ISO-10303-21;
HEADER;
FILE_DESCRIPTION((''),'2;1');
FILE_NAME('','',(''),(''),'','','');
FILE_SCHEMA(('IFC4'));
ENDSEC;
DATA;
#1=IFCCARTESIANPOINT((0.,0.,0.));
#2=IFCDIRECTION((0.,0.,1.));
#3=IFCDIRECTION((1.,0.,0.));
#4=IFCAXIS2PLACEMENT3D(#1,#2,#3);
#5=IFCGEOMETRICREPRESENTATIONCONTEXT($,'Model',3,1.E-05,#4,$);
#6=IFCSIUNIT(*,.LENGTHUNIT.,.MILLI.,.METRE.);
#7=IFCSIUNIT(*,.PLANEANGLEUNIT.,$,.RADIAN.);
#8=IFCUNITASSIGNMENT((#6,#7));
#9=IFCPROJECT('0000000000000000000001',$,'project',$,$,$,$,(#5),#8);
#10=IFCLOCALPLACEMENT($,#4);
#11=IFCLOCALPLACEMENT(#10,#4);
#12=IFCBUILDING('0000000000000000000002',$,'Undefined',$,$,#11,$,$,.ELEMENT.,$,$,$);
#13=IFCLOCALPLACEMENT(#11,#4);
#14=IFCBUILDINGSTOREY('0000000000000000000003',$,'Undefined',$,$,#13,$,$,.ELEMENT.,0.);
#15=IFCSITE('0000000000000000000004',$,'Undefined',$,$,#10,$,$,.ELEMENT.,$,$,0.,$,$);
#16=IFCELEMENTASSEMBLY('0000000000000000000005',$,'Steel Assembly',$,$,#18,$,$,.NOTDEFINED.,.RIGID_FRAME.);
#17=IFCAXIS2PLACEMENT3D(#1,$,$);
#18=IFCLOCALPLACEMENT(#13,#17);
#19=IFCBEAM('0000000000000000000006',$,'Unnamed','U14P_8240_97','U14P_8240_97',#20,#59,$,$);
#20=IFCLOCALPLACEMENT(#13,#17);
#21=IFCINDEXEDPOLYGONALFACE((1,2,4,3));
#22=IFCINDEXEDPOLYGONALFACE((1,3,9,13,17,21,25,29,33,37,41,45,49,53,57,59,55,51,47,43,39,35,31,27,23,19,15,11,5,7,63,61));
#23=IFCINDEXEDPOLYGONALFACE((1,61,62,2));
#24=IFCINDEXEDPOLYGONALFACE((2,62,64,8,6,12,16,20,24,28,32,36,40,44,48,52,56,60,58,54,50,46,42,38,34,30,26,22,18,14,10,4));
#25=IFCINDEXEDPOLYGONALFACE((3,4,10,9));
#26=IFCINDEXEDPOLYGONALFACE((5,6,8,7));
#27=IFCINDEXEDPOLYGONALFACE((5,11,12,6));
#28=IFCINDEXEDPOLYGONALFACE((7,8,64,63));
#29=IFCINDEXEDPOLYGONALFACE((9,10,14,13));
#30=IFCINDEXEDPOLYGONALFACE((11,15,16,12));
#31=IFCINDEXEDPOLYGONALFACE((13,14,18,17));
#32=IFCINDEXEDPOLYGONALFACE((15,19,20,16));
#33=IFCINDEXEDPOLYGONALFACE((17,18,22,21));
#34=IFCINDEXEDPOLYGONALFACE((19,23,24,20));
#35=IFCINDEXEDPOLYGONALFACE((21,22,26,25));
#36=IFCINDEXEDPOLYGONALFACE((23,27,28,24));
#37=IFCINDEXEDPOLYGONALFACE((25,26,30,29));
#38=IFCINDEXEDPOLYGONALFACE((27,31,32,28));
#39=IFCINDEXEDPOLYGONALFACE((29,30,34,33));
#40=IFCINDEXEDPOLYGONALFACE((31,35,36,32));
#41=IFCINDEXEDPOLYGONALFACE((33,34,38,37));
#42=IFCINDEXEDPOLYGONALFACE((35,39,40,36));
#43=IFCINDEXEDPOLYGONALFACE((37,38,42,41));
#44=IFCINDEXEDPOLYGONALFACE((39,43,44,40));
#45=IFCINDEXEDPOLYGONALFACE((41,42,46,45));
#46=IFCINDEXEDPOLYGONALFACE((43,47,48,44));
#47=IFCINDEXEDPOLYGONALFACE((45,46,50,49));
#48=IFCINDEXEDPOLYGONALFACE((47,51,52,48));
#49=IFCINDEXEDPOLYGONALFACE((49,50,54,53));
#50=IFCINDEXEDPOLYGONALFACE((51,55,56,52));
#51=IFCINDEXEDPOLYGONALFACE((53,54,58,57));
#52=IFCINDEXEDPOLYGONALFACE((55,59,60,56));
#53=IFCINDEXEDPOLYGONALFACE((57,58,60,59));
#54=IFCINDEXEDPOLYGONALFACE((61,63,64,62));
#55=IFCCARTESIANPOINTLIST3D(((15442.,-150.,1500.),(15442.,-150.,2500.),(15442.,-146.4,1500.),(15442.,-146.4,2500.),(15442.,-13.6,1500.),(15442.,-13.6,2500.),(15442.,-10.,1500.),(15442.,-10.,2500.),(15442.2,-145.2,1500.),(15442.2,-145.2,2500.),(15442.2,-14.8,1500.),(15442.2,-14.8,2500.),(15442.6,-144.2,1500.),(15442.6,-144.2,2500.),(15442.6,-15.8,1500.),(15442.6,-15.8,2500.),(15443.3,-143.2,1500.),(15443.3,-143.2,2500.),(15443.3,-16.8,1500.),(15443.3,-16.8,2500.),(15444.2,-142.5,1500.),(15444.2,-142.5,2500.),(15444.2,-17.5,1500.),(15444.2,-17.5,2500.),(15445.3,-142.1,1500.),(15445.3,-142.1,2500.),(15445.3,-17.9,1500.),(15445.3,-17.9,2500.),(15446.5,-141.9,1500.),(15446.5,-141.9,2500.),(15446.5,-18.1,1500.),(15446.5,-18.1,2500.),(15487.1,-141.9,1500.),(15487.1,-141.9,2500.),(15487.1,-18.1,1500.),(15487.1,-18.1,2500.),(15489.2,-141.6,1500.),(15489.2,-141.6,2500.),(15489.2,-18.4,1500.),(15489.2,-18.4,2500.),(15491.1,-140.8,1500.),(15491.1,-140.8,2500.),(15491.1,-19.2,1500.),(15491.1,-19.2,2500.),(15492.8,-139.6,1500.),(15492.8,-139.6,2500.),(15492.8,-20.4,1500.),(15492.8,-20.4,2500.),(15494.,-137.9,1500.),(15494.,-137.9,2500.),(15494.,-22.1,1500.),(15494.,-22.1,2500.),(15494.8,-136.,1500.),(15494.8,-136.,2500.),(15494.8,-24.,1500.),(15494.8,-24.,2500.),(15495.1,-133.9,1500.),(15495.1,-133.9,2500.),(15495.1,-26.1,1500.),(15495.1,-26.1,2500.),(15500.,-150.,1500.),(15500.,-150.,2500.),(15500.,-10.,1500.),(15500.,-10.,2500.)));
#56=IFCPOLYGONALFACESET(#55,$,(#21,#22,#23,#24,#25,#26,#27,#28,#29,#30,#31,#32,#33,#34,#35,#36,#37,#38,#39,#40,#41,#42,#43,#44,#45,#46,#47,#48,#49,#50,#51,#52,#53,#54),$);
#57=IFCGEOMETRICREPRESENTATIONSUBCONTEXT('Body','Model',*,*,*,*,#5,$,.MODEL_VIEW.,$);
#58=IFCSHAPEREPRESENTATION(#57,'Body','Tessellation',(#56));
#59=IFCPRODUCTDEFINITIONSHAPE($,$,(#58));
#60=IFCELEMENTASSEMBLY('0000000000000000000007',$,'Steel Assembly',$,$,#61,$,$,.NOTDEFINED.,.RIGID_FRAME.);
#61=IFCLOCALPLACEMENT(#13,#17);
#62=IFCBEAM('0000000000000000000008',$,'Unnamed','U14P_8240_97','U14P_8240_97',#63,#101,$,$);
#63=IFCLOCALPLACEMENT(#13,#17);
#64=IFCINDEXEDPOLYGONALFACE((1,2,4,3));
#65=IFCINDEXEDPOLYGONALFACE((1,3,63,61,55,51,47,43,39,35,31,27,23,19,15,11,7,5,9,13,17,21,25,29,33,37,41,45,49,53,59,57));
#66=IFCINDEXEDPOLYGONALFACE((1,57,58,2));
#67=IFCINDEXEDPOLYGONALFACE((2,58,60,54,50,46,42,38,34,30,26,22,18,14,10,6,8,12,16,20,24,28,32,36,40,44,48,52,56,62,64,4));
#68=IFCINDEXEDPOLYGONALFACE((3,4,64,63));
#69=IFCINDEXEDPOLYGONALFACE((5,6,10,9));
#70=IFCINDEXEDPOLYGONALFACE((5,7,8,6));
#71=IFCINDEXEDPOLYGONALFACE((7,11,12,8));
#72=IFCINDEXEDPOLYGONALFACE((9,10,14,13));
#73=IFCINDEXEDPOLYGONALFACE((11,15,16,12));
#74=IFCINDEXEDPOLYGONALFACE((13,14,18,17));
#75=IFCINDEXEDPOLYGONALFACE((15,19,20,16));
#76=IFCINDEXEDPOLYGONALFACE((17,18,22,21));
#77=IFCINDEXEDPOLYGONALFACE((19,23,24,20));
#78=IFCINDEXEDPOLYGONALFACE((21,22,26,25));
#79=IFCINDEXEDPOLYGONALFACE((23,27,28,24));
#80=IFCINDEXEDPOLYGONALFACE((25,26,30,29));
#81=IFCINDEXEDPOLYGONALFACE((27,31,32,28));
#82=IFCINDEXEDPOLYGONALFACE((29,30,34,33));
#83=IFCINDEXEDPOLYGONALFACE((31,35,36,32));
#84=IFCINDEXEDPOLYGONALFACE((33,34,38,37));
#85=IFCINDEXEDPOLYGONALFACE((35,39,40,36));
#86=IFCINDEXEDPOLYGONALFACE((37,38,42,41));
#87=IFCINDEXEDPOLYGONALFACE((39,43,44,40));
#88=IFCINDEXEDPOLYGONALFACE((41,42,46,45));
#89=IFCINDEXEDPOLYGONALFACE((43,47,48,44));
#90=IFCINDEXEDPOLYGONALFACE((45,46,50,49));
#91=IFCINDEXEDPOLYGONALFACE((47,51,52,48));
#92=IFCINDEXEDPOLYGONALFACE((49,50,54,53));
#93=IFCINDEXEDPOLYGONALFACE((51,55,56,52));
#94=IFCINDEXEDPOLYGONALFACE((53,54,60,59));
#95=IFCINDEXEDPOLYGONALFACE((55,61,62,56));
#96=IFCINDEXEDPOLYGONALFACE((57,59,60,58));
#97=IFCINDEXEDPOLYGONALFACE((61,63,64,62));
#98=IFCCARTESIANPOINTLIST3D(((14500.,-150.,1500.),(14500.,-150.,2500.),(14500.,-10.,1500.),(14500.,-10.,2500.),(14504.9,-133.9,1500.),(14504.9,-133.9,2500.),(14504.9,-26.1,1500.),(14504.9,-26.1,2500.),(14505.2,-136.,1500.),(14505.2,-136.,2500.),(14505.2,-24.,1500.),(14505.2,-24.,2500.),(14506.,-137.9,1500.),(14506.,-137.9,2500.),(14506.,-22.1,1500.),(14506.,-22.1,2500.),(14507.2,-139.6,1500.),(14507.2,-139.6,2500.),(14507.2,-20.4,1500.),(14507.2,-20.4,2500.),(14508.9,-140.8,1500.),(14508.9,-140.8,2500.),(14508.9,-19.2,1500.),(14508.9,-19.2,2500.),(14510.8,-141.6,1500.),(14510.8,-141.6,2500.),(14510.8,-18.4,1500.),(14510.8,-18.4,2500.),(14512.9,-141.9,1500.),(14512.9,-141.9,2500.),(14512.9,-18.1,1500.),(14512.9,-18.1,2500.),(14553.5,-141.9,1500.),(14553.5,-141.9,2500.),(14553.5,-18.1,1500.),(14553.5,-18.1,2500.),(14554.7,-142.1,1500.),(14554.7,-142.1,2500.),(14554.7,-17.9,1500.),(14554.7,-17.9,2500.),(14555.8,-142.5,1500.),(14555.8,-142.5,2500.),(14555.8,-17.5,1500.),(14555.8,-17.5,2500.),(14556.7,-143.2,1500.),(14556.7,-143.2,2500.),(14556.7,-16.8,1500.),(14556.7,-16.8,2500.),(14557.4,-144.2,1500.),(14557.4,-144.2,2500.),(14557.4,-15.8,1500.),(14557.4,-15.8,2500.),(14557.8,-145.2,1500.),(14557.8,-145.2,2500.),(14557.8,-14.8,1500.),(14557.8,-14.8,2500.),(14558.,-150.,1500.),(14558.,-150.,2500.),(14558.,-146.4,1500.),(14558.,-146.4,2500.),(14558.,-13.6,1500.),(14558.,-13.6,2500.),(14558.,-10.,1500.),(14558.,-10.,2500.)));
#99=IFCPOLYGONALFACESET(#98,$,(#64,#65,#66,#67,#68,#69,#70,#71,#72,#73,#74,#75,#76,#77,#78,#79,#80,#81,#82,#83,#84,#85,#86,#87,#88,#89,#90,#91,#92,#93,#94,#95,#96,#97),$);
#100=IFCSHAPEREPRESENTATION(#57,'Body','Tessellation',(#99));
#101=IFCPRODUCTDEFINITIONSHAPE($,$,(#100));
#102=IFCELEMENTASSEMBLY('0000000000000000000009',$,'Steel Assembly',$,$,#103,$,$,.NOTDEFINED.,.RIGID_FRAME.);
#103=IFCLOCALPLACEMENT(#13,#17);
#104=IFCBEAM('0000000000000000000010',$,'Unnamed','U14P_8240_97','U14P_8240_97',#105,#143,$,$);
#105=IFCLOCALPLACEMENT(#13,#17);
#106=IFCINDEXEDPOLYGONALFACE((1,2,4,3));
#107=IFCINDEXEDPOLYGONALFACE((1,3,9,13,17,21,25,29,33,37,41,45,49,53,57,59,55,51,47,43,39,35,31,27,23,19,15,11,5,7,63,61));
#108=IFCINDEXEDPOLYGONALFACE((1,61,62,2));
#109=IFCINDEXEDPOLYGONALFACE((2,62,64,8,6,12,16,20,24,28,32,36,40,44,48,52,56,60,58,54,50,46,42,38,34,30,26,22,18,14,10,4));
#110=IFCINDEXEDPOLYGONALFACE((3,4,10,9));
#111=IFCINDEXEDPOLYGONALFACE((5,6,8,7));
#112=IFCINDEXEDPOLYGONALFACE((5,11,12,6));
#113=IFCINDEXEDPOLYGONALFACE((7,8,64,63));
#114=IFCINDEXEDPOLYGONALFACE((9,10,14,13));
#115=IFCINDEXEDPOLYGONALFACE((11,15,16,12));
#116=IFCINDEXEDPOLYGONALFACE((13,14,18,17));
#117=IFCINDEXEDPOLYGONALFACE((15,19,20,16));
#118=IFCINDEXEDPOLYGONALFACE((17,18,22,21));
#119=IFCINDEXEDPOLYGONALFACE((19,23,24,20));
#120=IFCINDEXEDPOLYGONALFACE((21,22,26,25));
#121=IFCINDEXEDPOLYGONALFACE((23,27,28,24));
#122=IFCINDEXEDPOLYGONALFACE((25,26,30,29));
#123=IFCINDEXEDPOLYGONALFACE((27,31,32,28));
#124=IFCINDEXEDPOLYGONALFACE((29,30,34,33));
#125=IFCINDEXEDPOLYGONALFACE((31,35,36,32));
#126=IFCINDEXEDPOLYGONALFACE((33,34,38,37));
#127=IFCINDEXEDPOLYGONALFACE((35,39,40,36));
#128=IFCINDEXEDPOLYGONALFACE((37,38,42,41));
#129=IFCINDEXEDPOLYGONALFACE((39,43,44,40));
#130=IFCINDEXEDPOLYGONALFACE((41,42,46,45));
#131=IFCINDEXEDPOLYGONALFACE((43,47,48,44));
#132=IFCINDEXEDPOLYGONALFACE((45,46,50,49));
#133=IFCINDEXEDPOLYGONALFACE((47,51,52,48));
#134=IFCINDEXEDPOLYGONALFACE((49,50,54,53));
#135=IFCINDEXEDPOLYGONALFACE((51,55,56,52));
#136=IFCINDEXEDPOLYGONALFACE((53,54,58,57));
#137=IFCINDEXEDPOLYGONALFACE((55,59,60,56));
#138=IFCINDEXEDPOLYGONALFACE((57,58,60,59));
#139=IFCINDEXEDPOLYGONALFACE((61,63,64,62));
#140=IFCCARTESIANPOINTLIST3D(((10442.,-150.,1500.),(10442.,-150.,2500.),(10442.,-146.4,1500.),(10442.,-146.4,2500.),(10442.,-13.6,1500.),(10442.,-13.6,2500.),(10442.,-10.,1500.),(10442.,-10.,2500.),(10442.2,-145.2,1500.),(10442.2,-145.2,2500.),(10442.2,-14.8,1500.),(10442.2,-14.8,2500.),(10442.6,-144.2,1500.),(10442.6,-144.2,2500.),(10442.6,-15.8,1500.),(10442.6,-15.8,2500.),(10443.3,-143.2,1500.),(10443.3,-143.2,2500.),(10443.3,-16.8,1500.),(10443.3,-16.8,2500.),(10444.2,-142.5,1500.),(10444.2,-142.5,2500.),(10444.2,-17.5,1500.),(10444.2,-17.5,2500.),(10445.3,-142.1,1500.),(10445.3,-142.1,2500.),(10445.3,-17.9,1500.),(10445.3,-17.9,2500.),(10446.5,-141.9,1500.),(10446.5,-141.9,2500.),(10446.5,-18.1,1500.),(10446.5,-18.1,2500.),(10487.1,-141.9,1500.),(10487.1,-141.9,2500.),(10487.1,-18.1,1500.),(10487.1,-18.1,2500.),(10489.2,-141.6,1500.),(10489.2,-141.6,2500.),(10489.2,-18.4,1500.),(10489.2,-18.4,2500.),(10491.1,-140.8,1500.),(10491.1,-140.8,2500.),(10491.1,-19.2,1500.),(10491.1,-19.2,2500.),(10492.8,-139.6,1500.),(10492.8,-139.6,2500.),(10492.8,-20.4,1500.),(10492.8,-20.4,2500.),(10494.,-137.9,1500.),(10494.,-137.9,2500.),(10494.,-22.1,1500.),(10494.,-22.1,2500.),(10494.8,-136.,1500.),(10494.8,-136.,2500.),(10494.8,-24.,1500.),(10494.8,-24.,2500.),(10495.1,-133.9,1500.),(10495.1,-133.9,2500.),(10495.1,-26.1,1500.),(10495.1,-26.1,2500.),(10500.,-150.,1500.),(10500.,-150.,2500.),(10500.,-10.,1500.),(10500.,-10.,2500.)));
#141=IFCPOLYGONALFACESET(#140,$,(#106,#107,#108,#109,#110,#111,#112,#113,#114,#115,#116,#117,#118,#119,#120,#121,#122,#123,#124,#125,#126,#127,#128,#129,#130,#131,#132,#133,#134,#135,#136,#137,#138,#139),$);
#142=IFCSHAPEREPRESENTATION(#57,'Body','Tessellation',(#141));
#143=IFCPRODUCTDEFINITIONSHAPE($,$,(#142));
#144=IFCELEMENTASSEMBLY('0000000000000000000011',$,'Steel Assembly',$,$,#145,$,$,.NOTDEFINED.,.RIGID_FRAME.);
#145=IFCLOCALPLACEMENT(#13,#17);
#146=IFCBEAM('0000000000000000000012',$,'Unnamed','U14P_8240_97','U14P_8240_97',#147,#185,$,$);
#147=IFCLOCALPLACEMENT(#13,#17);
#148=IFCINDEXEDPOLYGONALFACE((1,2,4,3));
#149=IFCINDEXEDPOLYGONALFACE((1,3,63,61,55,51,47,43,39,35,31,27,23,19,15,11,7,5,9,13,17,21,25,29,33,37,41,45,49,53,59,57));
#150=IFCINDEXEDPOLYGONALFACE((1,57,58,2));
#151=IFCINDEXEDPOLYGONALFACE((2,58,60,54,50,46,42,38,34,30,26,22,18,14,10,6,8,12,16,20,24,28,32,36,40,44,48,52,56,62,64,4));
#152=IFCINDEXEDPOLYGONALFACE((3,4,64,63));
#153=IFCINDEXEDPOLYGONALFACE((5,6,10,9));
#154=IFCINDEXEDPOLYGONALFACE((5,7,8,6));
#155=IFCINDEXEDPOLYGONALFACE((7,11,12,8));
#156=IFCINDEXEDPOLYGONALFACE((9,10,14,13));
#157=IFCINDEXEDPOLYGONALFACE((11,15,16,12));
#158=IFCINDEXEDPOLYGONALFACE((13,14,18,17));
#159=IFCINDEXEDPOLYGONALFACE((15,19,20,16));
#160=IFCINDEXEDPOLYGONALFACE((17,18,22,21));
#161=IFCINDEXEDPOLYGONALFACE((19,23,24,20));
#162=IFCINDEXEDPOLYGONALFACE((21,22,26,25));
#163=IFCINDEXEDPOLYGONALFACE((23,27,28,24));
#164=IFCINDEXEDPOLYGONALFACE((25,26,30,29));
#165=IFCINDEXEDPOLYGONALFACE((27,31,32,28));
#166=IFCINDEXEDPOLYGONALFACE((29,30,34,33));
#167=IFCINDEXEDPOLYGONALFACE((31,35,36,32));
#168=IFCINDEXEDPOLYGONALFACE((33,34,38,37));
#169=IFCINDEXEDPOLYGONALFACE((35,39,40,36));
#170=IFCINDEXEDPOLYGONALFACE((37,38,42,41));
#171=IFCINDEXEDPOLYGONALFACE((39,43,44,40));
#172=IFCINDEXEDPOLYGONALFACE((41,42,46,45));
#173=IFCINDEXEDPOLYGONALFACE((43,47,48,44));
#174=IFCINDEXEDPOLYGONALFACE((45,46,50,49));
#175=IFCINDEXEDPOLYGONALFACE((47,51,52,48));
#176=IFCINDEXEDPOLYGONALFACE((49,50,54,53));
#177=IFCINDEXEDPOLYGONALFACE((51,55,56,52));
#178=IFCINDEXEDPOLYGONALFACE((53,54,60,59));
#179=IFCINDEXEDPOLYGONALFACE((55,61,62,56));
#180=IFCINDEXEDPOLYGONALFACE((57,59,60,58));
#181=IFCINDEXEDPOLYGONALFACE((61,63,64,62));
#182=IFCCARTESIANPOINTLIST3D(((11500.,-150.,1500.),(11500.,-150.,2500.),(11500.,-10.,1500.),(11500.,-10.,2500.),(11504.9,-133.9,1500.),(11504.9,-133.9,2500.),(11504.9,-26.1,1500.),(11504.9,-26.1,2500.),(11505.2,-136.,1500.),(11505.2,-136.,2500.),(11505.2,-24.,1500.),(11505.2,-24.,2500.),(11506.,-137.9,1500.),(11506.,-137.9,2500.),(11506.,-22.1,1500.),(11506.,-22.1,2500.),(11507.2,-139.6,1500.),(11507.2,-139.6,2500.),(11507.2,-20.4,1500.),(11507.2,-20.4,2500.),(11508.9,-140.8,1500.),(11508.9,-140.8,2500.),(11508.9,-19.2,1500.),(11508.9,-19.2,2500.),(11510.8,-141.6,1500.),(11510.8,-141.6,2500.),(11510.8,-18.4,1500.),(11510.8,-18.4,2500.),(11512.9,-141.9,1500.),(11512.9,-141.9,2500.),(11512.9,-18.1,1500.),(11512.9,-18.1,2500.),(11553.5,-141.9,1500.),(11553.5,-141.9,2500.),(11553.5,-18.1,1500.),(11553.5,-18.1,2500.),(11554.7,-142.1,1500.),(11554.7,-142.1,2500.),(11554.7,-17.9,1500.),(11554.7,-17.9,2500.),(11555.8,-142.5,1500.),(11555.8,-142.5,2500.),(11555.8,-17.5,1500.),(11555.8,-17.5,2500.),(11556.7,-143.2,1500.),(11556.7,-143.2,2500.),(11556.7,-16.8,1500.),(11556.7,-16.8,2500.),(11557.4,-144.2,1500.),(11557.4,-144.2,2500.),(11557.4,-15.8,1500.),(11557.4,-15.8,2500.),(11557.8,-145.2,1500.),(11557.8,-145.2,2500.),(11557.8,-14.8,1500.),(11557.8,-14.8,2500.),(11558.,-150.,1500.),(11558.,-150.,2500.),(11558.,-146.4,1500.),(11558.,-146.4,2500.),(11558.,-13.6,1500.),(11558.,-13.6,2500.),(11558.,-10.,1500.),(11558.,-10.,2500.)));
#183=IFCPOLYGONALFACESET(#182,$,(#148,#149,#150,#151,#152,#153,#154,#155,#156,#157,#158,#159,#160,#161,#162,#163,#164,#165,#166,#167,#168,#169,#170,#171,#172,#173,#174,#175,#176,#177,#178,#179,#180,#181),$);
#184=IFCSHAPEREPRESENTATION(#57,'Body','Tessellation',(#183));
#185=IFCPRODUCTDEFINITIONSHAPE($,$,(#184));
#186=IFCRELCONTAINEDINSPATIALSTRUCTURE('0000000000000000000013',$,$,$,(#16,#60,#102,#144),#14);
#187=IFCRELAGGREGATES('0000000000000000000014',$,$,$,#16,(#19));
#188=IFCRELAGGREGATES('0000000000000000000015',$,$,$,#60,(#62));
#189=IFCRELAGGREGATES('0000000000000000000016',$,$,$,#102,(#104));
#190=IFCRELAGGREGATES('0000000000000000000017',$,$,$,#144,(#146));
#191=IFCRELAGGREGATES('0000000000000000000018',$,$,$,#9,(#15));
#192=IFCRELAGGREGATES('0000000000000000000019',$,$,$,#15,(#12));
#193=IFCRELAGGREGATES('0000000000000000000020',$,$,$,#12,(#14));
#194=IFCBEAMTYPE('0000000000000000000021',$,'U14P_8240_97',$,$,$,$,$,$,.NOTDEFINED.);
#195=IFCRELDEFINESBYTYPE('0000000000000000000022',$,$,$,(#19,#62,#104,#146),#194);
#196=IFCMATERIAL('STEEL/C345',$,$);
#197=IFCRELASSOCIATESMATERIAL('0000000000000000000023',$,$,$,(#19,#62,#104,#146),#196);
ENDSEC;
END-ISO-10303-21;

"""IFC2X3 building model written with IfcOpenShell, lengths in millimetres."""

from ifc_helpers import new_model, si_unit, frame, origin_with_axes, origin_2d_with_axis, place, context, subcontext, project, spatial, u_section, extrude, material, type_object, element, aggregate, save


model = new_model("IFC2X3")

# Units and contexts
model_context = context("Model", 3, precision=1e-05, world=origin_with_axes())
body_context = subcontext(model_context, "Body", "Model", "MODEL_VIEW")
ifc_project = project(units=[si_unit("LENGTHUNIT", "METRE", prefix="MILLI"), si_unit("PLANEANGLEUNIT", "RADIAN")], contexts=[model_context])

# Site, building, storey
site_placement = place(None, origin_with_axes())
site = spatial("IfcSite", under=ifc_project, at=site_placement, Name="Undefined", CompositionType="ELEMENT", RefElevation=0.0)
building_placement = place(site_placement, origin_with_axes())
building = spatial("IfcBuilding", under=site, at=building_placement, Name="Undefined", CompositionType="ELEMENT")
storey_placement = place(building_placement, origin_with_axes())
storey = spatial("IfcBuildingStorey", under=building, at=storey_placement, Name="Undefined", CompositionType="ELEMENT", Elevation=0.0)

# Shared definitions
ifc_material_1 = material(Name="STEEL/C345")

# Element assemblies, beams
assembly_1_placement = place(storey_placement, origin_with_axes())
assembly_1 = element("IfcElementAssembly", 1, at=assembly_1_placement, inside=storey, Name="Steel Assembly", AssemblyPlace="NOTDEFINED", PredefinedType="RIGID_FRAME")
beam_type_1 = type_object("IfcBeamType", Name="U14P_8240_97", PredefinedType="NOTDEFINED")
beam_1_placement = place(assembly_1_placement, frame((15471.0, -80.0, 2500.0), z_axis=(0.0, -1.0, 0.0), x_axis=(0.0, 0.0, -1.0)))
beam_1 = element("IfcBeam", 2, at=beam_1_placement, type_object=beam_type_1, material=ifc_material_1, Name="Unnamed", Description="U14P_8240_97", ObjectType="U14P_8240_97", context=body_context, shape_type="SweptSolid", body=[
    extrude(u_section(Depth=140.0, FlangeWidth=58.0, WebThickness=4.9, FlangeThickness=8.1, FilletRadius=8.0, EdgeRadius=4.5, at=origin_2d_with_axis()), frame((1000.0, 0.0, 0.0), z_axis=(-1.0, 0.0, 0.0), x_axis=(0.0, -1.0, 0.0)), (0.0, 0.0, 1.0), 1000.0),
])
aggregate(assembly_1, [beam_1])
assembly_2_placement = place(storey_placement, origin_with_axes())
assembly_2 = element("IfcElementAssembly", 3, at=assembly_2_placement, inside=storey, Name="Steel Assembly", AssemblyPlace="NOTDEFINED", PredefinedType="RIGID_FRAME")
beam_2_placement = place(assembly_2_placement, frame((14529.0, -80.0, 2500.0), z_axis=(0.0, 1.0, 0.0), x_axis=(0.0, 0.0, -1.0)))
beam_2 = element("IfcBeam", 4, at=beam_2_placement, type_object=beam_type_1, material=ifc_material_1, Name="Unnamed", Description="U14P_8240_97", ObjectType="U14P_8240_97", context=body_context, shape_type="SweptSolid", body=[
    extrude(u_section(Depth=140.0, FlangeWidth=58.0, WebThickness=4.9, FlangeThickness=8.1, FilletRadius=8.0, EdgeRadius=4.5, at=origin_2d_with_axis()), frame((1000.0, 0.0, 0.0), z_axis=(-1.0, 0.0, 0.0), x_axis=(0.0, -1.0, 0.0)), (0.0, 0.0, 1.0), 1000.0),
])
aggregate(assembly_2, [beam_2])
assembly_3_placement = place(storey_placement, origin_with_axes())
assembly_3 = element("IfcElementAssembly", 5, at=assembly_3_placement, inside=storey, Name="Steel Assembly", AssemblyPlace="NOTDEFINED", PredefinedType="RIGID_FRAME")
beam_3_placement = place(assembly_3_placement, frame((10471.0, -80.0, 2500.0), z_axis=(0.0, -1.0, 0.0), x_axis=(0.0, 0.0, -1.0)))
beam_3 = element("IfcBeam", 6, at=beam_3_placement, type_object=beam_type_1, material=ifc_material_1, Name="Unnamed", Description="U14P_8240_97", ObjectType="U14P_8240_97", context=body_context, shape_type="SweptSolid", body=[
    extrude(u_section(Depth=140.0, FlangeWidth=58.0, WebThickness=4.9, FlangeThickness=8.1, FilletRadius=8.0, EdgeRadius=4.5, at=origin_2d_with_axis()), frame((1000.0, 0.0, 0.0), z_axis=(-1.0, 0.0, 0.0), x_axis=(0.0, -1.0, 0.0)), (0.0, 0.0, 1.0), 1000.0),
])
aggregate(assembly_3, [beam_3])
assembly_4_placement = place(storey_placement, origin_with_axes())
assembly_4 = element("IfcElementAssembly", 7, at=assembly_4_placement, inside=storey, Name="Steel Assembly", AssemblyPlace="NOTDEFINED", PredefinedType="RIGID_FRAME")
beam_4_placement = place(assembly_4_placement, frame((11529.0, -80.0, 2500.0), z_axis=(0.0, 1.0, 0.0), x_axis=(0.0, 0.0, -1.0)))
beam_4 = element("IfcBeam", 8, at=beam_4_placement, type_object=beam_type_1, material=ifc_material_1, Name="Unnamed", Description="U14P_8240_97", ObjectType="U14P_8240_97", context=body_context, shape_type="SweptSolid", body=[
    extrude(u_section(Depth=140.0, FlangeWidth=58.0, WebThickness=4.9, FlangeThickness=8.1, FilletRadius=8.0, EdgeRadius=4.5, at=origin_2d_with_axis()), frame((1000.0, 0.0, 0.0), z_axis=(-1.0, 0.0, 0.0), x_axis=(0.0, -1.0, 0.0)), (0.0, 0.0, 1.0), 1000.0),
])
aggregate(assembly_4, [beam_4])

save(model, "model.ifc")
